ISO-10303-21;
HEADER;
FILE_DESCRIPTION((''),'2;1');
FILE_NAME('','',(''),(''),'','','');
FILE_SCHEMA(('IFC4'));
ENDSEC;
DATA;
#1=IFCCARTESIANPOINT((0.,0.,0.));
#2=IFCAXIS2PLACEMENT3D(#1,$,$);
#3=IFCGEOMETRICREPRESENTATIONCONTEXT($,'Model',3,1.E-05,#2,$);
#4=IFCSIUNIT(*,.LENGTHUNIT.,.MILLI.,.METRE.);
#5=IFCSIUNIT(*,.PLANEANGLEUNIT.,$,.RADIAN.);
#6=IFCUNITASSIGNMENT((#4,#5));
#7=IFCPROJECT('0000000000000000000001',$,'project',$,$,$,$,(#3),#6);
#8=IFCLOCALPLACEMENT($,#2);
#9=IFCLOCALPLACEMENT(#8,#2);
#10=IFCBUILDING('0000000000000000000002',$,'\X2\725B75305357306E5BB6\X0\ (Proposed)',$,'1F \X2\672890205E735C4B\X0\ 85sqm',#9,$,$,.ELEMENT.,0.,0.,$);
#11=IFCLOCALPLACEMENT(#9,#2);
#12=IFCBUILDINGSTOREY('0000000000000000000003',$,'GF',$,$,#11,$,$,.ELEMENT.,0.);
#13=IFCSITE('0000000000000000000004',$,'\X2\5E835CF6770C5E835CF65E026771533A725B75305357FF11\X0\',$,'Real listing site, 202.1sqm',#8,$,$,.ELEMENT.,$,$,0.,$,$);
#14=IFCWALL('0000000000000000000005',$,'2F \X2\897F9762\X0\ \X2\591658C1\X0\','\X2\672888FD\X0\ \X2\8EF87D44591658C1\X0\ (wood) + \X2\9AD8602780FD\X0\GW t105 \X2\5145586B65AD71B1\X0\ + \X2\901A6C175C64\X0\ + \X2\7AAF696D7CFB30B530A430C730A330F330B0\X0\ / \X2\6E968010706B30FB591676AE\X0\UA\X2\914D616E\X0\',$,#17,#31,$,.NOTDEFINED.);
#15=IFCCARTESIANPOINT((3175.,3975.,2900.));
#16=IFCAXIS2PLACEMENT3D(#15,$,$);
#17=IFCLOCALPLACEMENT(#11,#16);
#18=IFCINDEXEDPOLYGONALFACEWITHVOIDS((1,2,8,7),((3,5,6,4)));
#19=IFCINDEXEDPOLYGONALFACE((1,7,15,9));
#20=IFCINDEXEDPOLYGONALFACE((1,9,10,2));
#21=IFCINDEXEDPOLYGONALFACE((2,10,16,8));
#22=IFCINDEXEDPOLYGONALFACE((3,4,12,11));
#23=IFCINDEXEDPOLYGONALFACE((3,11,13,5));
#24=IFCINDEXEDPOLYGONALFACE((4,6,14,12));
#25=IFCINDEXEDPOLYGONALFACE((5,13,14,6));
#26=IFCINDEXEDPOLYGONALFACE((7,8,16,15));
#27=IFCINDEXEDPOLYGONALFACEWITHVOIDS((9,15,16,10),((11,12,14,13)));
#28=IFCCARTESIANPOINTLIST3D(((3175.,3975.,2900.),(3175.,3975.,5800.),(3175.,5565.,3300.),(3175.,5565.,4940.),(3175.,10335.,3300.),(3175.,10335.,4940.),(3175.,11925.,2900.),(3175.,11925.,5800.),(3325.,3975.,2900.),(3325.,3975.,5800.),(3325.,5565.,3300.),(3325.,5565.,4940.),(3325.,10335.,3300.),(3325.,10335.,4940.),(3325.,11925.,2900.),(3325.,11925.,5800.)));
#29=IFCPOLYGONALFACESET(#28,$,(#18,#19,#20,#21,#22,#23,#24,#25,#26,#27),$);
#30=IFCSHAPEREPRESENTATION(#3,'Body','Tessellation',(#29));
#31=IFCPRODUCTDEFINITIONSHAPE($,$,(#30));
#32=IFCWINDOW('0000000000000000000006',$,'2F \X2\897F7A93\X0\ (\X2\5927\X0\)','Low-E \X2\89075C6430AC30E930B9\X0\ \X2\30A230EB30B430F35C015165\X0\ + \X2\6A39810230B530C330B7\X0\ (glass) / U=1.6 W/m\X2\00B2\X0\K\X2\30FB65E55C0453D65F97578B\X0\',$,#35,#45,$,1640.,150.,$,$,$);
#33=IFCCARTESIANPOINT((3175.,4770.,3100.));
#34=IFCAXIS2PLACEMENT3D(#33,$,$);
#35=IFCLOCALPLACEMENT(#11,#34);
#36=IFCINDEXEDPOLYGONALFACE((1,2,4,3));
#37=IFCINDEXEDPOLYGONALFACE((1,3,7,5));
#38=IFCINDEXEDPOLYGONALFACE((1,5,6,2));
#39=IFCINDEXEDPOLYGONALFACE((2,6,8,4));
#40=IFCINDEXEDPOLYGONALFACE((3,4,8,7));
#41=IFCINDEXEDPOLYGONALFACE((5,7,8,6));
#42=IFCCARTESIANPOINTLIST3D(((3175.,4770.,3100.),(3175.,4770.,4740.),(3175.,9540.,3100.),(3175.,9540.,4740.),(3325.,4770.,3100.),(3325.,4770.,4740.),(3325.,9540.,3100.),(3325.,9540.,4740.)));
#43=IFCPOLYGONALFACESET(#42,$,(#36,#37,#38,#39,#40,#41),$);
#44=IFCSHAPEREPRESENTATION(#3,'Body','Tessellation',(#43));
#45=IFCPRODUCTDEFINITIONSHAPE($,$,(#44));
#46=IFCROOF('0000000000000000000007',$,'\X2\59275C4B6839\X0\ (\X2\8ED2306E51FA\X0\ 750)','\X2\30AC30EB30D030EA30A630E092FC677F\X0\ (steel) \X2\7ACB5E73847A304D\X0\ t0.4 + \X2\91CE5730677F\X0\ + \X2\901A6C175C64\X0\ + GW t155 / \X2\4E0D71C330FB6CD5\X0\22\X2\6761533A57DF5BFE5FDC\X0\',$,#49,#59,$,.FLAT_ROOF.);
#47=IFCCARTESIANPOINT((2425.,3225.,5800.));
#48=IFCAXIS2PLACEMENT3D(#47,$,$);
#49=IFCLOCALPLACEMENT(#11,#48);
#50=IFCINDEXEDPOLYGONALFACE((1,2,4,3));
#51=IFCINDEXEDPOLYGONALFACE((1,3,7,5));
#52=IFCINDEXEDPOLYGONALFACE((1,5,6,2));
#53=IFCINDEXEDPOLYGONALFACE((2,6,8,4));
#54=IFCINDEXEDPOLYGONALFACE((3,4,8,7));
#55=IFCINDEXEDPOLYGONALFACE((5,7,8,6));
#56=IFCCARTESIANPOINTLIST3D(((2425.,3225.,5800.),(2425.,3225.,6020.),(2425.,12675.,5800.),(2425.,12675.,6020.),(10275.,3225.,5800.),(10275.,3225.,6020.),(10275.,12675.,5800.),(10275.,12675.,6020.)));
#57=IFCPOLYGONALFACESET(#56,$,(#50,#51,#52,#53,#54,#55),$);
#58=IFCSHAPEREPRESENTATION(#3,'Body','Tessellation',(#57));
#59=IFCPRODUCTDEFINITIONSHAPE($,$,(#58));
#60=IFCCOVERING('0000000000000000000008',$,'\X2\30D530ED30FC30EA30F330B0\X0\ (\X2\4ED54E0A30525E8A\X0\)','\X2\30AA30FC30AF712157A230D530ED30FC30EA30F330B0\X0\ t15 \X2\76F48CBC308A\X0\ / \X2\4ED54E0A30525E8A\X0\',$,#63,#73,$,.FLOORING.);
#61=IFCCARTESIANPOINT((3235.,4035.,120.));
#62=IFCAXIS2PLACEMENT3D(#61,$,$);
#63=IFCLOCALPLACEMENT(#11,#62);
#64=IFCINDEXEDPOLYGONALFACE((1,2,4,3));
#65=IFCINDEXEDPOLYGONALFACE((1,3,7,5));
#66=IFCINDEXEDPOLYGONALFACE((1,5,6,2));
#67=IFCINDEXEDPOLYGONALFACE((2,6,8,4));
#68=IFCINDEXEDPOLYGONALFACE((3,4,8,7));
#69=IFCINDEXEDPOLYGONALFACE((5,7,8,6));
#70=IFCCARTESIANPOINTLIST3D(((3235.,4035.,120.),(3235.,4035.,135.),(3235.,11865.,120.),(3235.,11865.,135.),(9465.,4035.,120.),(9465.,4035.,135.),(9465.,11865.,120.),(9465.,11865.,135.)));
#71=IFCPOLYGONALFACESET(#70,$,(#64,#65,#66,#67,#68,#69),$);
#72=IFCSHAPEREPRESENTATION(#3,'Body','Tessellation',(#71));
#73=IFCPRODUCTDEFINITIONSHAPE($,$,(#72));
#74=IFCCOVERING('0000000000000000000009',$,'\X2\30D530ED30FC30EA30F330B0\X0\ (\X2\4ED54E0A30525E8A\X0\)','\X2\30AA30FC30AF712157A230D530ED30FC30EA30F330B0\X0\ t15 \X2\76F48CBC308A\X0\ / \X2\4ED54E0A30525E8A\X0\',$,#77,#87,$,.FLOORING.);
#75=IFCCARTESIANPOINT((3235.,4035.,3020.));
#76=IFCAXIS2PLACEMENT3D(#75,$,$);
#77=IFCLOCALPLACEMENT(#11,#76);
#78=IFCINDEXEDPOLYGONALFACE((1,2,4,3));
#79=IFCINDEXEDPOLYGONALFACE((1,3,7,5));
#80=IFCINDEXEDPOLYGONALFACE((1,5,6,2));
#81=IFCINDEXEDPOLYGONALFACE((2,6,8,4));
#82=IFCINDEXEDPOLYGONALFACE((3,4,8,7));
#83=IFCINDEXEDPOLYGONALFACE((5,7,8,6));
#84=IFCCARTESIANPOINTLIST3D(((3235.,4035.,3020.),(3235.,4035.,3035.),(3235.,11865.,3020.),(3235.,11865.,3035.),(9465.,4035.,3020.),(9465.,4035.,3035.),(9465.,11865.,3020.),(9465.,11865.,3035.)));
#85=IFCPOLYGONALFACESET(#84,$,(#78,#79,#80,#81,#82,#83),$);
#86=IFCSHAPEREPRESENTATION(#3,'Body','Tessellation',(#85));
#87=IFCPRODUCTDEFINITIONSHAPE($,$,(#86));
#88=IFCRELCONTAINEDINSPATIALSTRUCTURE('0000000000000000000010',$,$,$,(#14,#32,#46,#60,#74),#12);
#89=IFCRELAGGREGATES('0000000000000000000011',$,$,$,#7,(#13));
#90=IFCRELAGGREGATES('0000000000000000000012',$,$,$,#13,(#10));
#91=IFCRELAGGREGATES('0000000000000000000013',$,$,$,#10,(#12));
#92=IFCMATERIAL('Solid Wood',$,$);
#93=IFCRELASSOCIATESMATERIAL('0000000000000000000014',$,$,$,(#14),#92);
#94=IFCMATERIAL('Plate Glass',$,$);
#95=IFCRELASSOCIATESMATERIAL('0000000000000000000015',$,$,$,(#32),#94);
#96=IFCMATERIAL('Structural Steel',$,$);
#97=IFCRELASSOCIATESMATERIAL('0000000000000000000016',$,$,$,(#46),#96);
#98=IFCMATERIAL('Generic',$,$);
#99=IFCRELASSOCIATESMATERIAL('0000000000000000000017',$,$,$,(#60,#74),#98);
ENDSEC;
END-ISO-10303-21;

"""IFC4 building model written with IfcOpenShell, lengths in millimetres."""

from ifc_helpers import new_model, si_unit, frame, frame_2d, origin, place, context, project, spatial, rectangle, extrude, material, element, fill, save


model = new_model("IFC4")

# Units and contexts
model_context = context("Model", 3, precision=1e-05, world=origin())
ifc_project = project(units=[si_unit("LENGTHUNIT", "METRE", prefix="MILLI"), si_unit("PLANEANGLEUNIT", "RADIAN")], contexts=[model_context])

# Site, building, storey
site_placement = place(None, origin())
site = spatial("IfcSite", under=ifc_project, at=site_placement, Name="広島県広島市東区牛田南１", ObjectType="Real listing site, 202.1sqm", CompositionType="ELEMENT", RefElevation=0.0)
building_placement = place(site_placement, origin())
building = spatial("IfcBuilding", under=site, at=building_placement, Name="牛田南の家 (Proposed)", ObjectType="1F 木造平屋 85sqm", CompositionType="ELEMENT", ElevationOfRefHeight=0.0, ElevationOfTerrain=0.0)
storey_placement = place(building_placement, origin())
storey = spatial("IfcBuildingStorey", under=building, at=storey_placement, Name="GF", CompositionType="ELEMENT", Elevation=0.0)

# Shared definitions
ifc_material_1 = material(Name="Solid Wood")
ifc_material_2 = material(Name="Generic")

# Shared definitions
ifc_material_3 = material(Name="Plate Glass")

# Wall, opening, window
wall_1_placement = place(storey_placement, frame((3175.0, 3975.0, 2900.0)))
wall_1 = element("IfcWall", 1, at=wall_1_placement, inside=storey, material=ifc_material_1, Name="2F 西面 外壁", Description="木製 軸組外壁 (wood) + 高性能GW t105 充填断熱 + 通気層 + 窯業系サイディング / 準耐火・外皮UA配慮", PredefinedType="NOTDEFINED", context=model_context, shape_type="SweptSolid", body=[
    extrude(rectangle(XDim=150.0, YDim=7950.0, at=frame_2d((75.0, 3975.0))), frame((3175.0, 3975.0, 2900.0)), (0.0, 0.0, 1.0), 2900.0),
])
opening_1_placement = place(storey_placement, frame((3175.0, 4770.0, 3100.0)))
opening_1 = element("IfcOpeningElement", 2, at=opening_1_placement, cuts=wall_1, PredefinedType="NOTDEFINED", context=model_context, shape_type="SweptSolid", body=[
    extrude(rectangle(XDim=150.0, YDim=4770.0, at=frame_2d((75.0, 2385.0))), frame((3175.0, 4770.0, 3100.0)), (0.0, 0.0, 1.0), 1640.0),
])
window_1_placement = place(storey_placement, frame((3175.0, 4770.0, 3100.0)))
window_1 = element("IfcWindow", 3, at=window_1_placement, inside=storey, material=ifc_material_3, Name="2F 西窓 (大)", Description="Low-E 複層ガラス アルゴン封入 + 樹脂サッシ (glass) / U=1.6 W/m²K・日射取得型", OverallHeight=1640.0, OverallWidth=150.0, context=model_context, shape_type="SweptSolid", body=[
    extrude(rectangle(XDim=150.0, YDim=4770.0, at=frame_2d((75.0, 2385.0))), frame((3175.0, 4770.0, 3100.0)), (0.0, 0.0, 1.0), 1640.0),
])
fill(opening_1, window_1)

# Roof
ifc_material_4 = material(Name="Structural Steel")
roof_placement = place(storey_placement, frame((2425.0, 3225.0, 5800.0)))
element("IfcRoof", 4, at=roof_placement, inside=storey, material=ifc_material_4, Name="大屋根 (軒の出 750)", Description="ガルバリウム鋼板 (steel) 立平葺き t0.4 + 野地板 + 通気層 + GW t155 / 不燃・法22条区域対応", PredefinedType="FLAT_ROOF", context=model_context, shape_type="SweptSolid", body=[
    extrude(rectangle(XDim=7850.0, YDim=9450.0, at=frame_2d((3925.0, 4725.0))), frame((2425.0, 3225.0, 5800.0)), (0.0, 0.0, 1.0), 220.0),
])

# Coverings
covering_1_placement = place(storey_placement, frame((3235.0, 4035.0, 120.0)))
element("IfcCovering", 5, at=covering_1_placement, inside=storey, material=ifc_material_2, Name="フローリング (仕上げ床)", Description="オーク無垢フローリング t15 直貼り / 仕上げ床", PredefinedType="FLOORING", context=model_context, shape_type="SweptSolid", body=[
    extrude(rectangle(XDim=6230.0, YDim=7830.0, at=frame_2d((3115.0, 3915.0))), frame((3235.0, 4035.0, 120.0)), (0.0, 0.0, 1.0), 15.0),
])
covering_2_placement = place(storey_placement, frame((3235.0, 4035.0, 3020.0)))
element("IfcCovering", 6, at=covering_2_placement, inside=storey, material=ifc_material_2, Name="フローリング (仕上げ床)", Description="オーク無垢フローリング t15 直貼り / 仕上げ床", PredefinedType="FLOORING", context=model_context, shape_type="SweptSolid", body=[
    extrude(rectangle(XDim=6230.0, YDim=7830.0, at=frame_2d((3115.0, 3915.0))), frame((3235.0, 4035.0, 3020.0)), (0.0, 0.0, 1.0), 15.0),
])

save(model, "model.ifc")
